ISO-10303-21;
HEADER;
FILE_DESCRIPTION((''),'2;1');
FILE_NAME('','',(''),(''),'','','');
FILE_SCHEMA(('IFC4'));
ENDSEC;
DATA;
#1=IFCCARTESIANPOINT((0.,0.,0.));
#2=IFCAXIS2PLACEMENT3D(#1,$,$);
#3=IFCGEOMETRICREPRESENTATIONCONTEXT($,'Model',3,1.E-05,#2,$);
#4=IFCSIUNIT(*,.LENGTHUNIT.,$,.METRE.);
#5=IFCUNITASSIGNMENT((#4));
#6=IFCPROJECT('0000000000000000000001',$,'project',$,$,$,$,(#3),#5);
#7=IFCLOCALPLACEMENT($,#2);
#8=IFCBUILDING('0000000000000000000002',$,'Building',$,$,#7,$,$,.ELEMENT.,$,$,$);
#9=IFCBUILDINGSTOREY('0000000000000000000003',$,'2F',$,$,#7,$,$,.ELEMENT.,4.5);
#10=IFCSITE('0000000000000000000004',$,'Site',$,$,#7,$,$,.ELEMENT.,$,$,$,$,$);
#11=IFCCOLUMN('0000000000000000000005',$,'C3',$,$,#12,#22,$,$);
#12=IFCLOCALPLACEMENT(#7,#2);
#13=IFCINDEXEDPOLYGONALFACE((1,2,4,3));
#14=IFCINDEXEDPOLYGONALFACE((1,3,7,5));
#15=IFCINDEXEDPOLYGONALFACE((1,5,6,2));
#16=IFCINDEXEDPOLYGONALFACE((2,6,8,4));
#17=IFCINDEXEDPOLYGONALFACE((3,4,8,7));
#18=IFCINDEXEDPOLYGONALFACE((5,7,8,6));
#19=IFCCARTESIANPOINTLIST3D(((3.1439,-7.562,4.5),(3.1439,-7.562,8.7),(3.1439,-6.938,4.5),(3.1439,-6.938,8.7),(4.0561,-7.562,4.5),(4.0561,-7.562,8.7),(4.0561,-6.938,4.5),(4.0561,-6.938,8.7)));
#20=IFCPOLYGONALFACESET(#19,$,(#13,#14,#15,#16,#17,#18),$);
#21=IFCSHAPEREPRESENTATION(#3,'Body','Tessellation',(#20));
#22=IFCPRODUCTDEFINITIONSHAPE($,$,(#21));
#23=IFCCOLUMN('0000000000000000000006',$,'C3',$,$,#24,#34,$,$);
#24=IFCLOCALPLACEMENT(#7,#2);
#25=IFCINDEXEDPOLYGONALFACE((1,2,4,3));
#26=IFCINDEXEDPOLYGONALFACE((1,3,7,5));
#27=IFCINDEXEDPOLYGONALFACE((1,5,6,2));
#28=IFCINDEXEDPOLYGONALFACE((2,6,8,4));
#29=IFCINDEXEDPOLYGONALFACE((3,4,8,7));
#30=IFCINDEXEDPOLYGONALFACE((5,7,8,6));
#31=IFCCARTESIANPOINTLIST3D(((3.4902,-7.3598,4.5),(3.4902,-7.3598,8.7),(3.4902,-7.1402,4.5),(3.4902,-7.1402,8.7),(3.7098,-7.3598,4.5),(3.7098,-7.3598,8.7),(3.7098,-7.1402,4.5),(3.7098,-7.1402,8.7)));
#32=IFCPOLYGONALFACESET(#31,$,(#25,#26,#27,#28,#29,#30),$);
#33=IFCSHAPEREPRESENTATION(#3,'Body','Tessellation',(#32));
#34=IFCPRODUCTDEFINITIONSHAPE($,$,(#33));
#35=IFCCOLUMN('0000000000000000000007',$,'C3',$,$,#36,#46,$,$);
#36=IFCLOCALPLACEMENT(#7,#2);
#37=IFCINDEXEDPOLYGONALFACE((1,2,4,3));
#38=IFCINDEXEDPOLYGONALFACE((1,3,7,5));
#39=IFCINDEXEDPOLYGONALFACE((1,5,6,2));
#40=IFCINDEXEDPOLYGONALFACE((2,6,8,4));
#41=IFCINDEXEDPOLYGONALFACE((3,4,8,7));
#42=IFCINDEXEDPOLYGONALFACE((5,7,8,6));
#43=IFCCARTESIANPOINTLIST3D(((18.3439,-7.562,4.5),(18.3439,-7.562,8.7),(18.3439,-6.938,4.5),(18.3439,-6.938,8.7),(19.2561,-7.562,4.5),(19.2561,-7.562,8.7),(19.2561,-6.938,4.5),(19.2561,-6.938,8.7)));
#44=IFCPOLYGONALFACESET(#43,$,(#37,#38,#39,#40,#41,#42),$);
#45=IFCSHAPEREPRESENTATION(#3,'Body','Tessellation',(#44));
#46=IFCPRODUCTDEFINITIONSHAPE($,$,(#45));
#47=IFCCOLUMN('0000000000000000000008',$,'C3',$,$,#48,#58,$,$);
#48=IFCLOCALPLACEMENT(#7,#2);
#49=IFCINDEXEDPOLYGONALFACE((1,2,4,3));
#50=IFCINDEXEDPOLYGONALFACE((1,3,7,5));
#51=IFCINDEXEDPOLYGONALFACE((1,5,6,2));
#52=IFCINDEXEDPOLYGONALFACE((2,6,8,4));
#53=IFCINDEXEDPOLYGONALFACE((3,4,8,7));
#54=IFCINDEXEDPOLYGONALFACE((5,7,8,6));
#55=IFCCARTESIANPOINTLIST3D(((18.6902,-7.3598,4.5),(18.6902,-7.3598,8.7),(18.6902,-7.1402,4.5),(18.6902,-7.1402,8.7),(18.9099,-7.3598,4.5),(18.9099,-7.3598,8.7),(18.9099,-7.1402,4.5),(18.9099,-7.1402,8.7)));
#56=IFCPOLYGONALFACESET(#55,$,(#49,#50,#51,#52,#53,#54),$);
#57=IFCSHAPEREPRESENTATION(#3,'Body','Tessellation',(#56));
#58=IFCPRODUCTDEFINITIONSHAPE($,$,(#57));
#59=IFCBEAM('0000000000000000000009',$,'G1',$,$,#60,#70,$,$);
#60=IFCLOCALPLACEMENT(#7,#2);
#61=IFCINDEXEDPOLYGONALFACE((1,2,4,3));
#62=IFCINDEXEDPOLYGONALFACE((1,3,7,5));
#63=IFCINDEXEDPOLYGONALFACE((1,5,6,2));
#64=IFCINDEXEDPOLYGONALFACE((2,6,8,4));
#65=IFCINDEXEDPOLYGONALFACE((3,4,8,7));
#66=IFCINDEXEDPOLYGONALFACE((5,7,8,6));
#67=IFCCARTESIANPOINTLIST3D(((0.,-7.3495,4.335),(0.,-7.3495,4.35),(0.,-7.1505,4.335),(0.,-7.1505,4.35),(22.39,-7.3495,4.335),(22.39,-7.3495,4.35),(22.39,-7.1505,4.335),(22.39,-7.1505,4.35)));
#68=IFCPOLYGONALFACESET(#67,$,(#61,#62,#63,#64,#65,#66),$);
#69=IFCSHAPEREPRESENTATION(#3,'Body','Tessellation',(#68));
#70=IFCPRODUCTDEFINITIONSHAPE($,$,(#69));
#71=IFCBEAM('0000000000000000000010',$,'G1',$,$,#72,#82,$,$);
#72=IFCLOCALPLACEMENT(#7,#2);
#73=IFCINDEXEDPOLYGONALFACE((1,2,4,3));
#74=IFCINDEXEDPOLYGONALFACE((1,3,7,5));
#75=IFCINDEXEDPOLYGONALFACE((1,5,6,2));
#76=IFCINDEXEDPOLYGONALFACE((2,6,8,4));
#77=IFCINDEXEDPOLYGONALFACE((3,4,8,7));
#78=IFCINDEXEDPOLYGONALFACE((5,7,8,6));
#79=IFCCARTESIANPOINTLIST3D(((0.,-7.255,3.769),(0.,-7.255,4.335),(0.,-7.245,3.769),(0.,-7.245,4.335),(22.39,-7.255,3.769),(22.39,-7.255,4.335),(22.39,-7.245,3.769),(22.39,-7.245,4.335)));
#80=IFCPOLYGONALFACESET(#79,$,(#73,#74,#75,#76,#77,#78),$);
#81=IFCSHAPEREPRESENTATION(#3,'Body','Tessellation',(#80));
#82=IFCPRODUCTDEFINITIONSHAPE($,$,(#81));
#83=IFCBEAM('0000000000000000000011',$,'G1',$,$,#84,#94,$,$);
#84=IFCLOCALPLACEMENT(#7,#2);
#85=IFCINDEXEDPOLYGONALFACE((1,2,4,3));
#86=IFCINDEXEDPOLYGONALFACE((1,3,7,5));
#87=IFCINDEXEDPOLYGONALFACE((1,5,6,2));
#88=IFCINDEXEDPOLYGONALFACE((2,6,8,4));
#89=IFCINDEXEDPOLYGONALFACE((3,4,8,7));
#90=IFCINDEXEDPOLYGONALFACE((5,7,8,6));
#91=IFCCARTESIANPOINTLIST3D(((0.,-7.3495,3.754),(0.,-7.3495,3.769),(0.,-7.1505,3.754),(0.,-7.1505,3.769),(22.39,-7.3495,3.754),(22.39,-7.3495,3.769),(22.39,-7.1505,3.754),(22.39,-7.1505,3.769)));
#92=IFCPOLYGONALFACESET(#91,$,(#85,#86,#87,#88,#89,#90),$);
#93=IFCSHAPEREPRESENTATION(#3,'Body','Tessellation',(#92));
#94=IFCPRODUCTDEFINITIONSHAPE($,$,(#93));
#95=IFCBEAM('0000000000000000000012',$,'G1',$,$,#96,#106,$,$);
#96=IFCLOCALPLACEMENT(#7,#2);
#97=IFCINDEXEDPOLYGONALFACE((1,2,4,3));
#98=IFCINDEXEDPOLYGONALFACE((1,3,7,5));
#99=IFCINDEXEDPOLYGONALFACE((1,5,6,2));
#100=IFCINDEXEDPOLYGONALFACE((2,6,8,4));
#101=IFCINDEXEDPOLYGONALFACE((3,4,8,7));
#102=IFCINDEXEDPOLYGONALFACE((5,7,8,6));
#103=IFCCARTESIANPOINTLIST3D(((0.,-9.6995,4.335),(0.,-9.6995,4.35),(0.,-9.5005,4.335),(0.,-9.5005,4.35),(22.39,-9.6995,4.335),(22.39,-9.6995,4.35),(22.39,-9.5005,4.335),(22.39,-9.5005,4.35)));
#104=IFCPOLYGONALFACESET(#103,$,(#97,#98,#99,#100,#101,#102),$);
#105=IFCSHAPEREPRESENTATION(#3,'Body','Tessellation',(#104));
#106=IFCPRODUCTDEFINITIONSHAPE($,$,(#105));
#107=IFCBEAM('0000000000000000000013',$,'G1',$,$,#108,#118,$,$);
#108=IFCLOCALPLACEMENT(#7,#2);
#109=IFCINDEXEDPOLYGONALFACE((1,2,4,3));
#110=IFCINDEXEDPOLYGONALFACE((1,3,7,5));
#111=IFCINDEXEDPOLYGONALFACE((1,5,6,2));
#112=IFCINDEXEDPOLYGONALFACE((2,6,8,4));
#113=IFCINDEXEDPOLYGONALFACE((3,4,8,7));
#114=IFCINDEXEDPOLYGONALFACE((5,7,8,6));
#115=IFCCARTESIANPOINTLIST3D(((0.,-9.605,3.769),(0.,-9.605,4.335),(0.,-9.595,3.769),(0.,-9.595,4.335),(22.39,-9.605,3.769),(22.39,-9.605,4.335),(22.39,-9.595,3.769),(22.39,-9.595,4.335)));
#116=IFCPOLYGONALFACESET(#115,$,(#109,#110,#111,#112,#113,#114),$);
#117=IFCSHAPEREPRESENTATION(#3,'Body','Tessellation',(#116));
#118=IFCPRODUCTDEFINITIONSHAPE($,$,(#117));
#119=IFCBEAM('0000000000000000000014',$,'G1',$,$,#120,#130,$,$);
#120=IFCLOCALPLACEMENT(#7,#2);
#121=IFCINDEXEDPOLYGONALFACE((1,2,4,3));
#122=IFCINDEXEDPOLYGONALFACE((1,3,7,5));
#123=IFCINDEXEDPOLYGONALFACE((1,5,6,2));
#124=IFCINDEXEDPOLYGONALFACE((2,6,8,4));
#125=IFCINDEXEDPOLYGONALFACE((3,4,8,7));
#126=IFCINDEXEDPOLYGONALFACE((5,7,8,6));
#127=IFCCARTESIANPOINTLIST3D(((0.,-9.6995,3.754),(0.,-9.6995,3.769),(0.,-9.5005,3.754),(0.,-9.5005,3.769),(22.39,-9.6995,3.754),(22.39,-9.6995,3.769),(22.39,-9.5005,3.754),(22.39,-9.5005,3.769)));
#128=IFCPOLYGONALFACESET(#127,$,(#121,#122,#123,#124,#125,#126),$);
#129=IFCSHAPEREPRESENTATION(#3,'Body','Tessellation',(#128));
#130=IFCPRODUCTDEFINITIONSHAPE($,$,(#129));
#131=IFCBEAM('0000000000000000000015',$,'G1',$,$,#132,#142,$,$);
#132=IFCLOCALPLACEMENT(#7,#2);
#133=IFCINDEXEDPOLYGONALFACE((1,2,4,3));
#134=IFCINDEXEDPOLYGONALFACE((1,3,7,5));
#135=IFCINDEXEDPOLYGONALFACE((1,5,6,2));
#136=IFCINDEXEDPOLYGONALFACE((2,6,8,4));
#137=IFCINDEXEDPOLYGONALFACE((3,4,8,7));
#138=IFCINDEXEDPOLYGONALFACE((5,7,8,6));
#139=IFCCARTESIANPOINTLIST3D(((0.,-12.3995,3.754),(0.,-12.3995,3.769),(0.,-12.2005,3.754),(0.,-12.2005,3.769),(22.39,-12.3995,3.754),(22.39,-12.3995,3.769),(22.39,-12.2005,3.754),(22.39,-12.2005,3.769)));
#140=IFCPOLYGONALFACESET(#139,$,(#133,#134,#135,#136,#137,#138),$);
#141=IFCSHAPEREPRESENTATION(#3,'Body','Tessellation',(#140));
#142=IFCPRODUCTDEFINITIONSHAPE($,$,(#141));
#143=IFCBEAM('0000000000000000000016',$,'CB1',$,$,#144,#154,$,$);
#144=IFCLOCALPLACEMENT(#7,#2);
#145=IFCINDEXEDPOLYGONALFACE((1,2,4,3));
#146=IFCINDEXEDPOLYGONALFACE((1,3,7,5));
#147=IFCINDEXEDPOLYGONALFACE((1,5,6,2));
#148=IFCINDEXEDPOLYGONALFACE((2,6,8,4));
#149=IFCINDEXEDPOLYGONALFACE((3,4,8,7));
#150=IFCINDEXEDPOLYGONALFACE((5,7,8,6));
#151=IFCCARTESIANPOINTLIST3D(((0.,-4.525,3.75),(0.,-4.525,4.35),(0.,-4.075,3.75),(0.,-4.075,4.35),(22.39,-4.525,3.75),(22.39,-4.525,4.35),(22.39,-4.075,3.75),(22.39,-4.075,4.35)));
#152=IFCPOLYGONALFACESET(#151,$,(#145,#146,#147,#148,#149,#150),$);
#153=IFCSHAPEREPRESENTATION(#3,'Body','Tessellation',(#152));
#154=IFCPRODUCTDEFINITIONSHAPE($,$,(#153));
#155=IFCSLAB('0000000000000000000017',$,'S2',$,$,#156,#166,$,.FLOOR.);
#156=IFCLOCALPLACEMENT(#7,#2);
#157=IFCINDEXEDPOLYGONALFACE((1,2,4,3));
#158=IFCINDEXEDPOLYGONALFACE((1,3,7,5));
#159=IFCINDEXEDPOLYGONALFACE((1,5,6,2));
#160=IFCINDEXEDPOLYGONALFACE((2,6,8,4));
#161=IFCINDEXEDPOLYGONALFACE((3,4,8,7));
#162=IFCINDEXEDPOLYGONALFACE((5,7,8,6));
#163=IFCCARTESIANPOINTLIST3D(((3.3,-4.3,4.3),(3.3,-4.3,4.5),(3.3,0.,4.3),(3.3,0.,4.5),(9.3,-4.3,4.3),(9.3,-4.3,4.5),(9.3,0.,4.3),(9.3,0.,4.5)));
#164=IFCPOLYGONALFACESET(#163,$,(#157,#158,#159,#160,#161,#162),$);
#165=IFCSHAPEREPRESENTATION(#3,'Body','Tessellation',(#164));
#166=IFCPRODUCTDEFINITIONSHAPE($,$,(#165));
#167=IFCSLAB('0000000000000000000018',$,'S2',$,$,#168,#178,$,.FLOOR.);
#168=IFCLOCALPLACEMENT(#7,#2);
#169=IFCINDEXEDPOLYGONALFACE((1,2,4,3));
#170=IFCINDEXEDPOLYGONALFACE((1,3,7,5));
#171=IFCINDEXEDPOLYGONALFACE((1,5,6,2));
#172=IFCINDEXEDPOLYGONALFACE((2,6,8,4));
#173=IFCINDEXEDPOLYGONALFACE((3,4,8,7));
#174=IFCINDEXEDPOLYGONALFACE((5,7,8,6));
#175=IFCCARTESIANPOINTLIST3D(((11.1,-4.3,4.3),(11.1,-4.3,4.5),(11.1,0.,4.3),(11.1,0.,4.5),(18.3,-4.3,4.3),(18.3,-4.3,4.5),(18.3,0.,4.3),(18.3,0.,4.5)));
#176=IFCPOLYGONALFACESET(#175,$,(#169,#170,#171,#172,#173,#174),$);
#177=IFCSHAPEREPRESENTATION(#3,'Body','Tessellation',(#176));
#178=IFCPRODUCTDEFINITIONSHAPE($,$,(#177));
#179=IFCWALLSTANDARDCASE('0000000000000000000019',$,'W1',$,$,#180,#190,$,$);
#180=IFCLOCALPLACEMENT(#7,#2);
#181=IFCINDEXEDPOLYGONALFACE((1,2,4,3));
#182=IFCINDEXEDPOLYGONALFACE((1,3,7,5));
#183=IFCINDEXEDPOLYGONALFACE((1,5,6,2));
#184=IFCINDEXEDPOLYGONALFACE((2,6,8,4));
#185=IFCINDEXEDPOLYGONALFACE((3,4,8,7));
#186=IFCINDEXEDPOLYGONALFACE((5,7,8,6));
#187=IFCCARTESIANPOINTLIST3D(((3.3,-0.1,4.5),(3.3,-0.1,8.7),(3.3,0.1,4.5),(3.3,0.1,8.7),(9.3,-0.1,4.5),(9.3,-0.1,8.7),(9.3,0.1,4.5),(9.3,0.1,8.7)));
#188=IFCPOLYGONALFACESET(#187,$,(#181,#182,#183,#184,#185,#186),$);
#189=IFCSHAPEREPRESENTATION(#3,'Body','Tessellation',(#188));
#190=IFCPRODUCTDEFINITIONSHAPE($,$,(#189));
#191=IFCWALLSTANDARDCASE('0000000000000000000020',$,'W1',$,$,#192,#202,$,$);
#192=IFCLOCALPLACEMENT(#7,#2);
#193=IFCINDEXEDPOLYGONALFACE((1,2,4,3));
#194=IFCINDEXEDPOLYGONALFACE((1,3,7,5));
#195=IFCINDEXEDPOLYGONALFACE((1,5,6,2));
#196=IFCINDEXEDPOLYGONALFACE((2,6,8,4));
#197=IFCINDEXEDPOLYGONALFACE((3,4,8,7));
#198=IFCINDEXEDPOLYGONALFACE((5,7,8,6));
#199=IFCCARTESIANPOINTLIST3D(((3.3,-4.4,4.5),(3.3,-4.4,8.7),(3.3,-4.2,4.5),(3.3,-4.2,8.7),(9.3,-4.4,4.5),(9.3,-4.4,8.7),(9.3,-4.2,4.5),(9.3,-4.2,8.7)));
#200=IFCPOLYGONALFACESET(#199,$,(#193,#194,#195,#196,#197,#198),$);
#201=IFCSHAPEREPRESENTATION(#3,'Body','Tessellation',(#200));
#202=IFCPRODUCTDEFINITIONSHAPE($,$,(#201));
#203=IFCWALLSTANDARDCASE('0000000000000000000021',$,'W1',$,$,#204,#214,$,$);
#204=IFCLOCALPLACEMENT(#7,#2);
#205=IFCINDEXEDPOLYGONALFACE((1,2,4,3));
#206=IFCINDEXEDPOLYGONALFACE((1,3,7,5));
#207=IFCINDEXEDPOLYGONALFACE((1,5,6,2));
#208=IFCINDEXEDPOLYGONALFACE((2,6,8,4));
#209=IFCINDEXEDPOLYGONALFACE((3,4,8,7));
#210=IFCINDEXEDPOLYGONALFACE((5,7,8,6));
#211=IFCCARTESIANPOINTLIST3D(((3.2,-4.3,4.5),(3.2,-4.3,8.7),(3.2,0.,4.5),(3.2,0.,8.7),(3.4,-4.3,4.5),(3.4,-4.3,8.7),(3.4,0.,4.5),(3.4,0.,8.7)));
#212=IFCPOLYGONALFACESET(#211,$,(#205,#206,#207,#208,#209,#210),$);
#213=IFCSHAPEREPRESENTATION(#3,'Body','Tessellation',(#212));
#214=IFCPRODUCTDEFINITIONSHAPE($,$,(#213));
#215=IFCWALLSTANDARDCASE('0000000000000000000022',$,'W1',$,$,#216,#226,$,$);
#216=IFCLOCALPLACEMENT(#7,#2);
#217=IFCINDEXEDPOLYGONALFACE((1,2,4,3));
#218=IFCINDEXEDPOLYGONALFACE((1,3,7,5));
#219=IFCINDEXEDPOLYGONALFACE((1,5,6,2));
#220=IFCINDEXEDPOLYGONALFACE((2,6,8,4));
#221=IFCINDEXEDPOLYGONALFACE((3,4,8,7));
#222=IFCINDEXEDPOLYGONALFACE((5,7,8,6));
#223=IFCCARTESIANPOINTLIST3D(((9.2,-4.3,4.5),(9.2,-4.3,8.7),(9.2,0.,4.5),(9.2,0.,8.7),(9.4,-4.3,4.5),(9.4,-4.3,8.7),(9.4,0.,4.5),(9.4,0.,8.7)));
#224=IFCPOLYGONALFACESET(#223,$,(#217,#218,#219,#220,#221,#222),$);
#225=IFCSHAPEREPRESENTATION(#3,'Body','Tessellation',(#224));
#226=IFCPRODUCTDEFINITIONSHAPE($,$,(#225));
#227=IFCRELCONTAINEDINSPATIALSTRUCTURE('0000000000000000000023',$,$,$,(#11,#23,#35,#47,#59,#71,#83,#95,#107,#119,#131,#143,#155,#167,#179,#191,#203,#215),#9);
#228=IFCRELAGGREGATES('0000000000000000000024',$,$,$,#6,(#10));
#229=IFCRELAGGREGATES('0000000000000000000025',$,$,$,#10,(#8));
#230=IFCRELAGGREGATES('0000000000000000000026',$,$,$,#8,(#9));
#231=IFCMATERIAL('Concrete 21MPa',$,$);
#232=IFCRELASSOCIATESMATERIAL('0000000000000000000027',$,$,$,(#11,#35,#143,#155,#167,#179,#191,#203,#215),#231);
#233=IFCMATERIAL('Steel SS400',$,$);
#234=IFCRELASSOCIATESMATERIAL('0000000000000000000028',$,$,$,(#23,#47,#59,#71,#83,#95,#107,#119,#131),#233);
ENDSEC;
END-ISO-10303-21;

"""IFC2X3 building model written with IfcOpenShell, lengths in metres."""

from ifc_helpers import new_model, si_unit, frame, origin, origin_2d, place, context, project, spatial, rectangle, extrude, material, element, save


model = new_model("IFC2X3")

# Units and contexts
model_context = context("Model", 3, precision=1e-05, world=origin())
ifc_project = project(units=[si_unit("LENGTHUNIT", "METRE")], contexts=[model_context])

# Site, building, storey
placement = place(None, origin())
site = spatial("IfcSite", under=ifc_project, at=placement, Name="Site", CompositionType="ELEMENT")
building = spatial("IfcBuilding", under=site, at=placement, Name="Building", CompositionType="ELEMENT")
storey = spatial("IfcBuildingStorey", under=building, at=placement, Name="2F", CompositionType="ELEMENT", Elevation=4.5)

# Columns
ifc_material_1 = material(Name="Concrete 21MPa")
column_1_placement = place(None, frame((3.6, -7.25, 4.5)))
element("IfcColumn", 1, at=column_1_placement, inside=storey, material=ifc_material_1, Name="C3", context=model_context, shape_type="SweptSolid", body=[
    extrude(rectangle(XDim=0.9121, YDim=0.6241, at=origin_2d()), origin(), (0.0, 0.0, 1.0), 4.2),
])
ifc_material_2 = material(Name="Steel SS400")
column_2_placement = place(None, frame((3.6, -7.25, 4.5)))
element("IfcColumn", 2, at=column_2_placement, inside=storey, material=ifc_material_2, Name="C3", context=model_context, shape_type="SweptSolid", body=[
    extrude(rectangle(XDim=0.2197, YDim=0.2197, at=origin_2d()), origin(), (0.0, 0.0, 1.0), 4.2),
])
column_3_placement = place(None, frame((18.8, -7.25, 4.5)))
element("IfcColumn", 3, at=column_3_placement, inside=storey, material=ifc_material_1, Name="C3", context=model_context, shape_type="SweptSolid", body=[
    extrude(rectangle(XDim=0.9121, YDim=0.6241, at=origin_2d()), origin(), (0.0, 0.0, 1.0), 4.2),
])
column_4_placement = place(None, frame((18.8, -7.25, 4.5)))
element("IfcColumn", 4, at=column_4_placement, inside=storey, material=ifc_material_2, Name="C3", context=model_context, shape_type="SweptSolid", body=[
    extrude(rectangle(XDim=0.2197, YDim=0.2197, at=origin_2d()), origin(), (0.0, 0.0, 1.0), 4.2),
])

# Beams
beam_1_placement = place(None, frame((11.195, -7.25, 4.335)))
element("IfcBeam", 5, at=beam_1_placement, inside=storey, material=ifc_material_2, Name="G1", context=model_context, shape_type="SweptSolid", body=[
    extrude(rectangle(XDim=22.39, YDim=0.199, at=origin_2d()), origin(), (0.0, 0.0, 1.0), 0.015),
])
beam_2_placement = place(None, frame((11.195, -7.25, 3.769)))
element("IfcBeam", 6, at=beam_2_placement, inside=storey, material=ifc_material_2, Name="G1", context=model_context, shape_type="SweptSolid", body=[
    extrude(rectangle(XDim=22.39, YDim=0.01, at=origin_2d()), origin(), (0.0, 0.0, 1.0), 0.566),
])
for number, where, name in (
    (7, (11.195, -7.25, 3.754), "G1"),
    (8, (11.195, -9.6, 4.335), "G1"),
):
    element("IfcBeam", number, at=place(None, frame(where)), inside=storey, material=ifc_material_2, Name=name, context=model_context, shape_type="SweptSolid", body=[
        extrude(rectangle(XDim=22.39, YDim=0.199, at=origin_2d()), origin(), (0.0, 0.0, 1.0), 0.015),
    ])
beam_3_placement = place(None, frame((11.195, -9.6, 3.769)))
element("IfcBeam", 9, at=beam_3_placement, inside=storey, material=ifc_material_2, Name="G1", context=model_context, shape_type="SweptSolid", body=[
    extrude(rectangle(XDim=22.39, YDim=0.01, at=origin_2d()), origin(), (0.0, 0.0, 1.0), 0.566),
])
for number, where, name in (
    (10, (11.195, -9.6, 3.754), "G1"),
    (11, (11.195, -12.3, 3.754), "G1"),
):
    element("IfcBeam", number, at=place(None, frame(where)), inside=storey, material=ifc_material_2, Name=name, context=model_context, shape_type="SweptSolid", body=[
        extrude(rectangle(XDim=22.39, YDim=0.199, at=origin_2d()), origin(), (0.0, 0.0, 1.0), 0.015),
    ])
beam_4_placement = place(None, frame((11.195, -4.3, 3.75)))
element("IfcBeam", 12, at=beam_4_placement, inside=storey, material=ifc_material_1, Name="CB1", context=model_context, shape_type="SweptSolid", body=[
    extrude(rectangle(XDim=22.39, YDim=0.45, at=origin_2d()), origin(), (0.0, 0.0, 1.0), 0.6),
])

# Slabs
slab_1_placement = place(None, frame((6.3, -2.15, 4.3)))
element("IfcSlab", 13, at=slab_1_placement, inside=storey, material=ifc_material_1, Name="S2", PredefinedType="FLOOR", context=model_context, shape_type="SweptSolid", body=[
    extrude(rectangle(XDim=6.0, YDim=4.3, at=origin_2d()), origin(), (0.0, 0.0, 1.0), 0.2),
])
slab_2_placement = place(None, frame((14.7, -2.15, 4.3)))
element("IfcSlab", 14, at=slab_2_placement, inside=storey, material=ifc_material_1, Name="S2", PredefinedType="FLOOR", context=model_context, shape_type="SweptSolid", body=[
    extrude(rectangle(XDim=7.2, YDim=4.3, at=origin_2d()), origin(), (0.0, 0.0, 1.0), 0.2),
])

# Walls
for number, where, name in (
    (15, (6.3, 0.0, 4.5), "W1"),
    (16, (6.3, -4.3, 4.5), "W1"),
):
    element("IfcWallStandardCase", number, at=place(None, frame(where)), inside=storey, material=ifc_material_1, Name=name, context=model_context, shape_type="SweptSolid", body=[
        extrude(rectangle(XDim=6.0, YDim=0.2, at=origin_2d()), origin(), (0.0, 0.0, 1.0), 4.2),
    ])
for number, where, name in (
    (17, (3.3, -2.15, 4.5), "W1"),
    (18, (9.3, -2.15, 4.5), "W1"),
):
    element("IfcWallStandardCase", number, at=place(None, frame(where)), inside=storey, material=ifc_material_1, Name=name, context=model_context, shape_type="SweptSolid", body=[
        extrude(rectangle(XDim=0.2, YDim=4.3, at=origin_2d()), origin(), (0.0, 0.0, 1.0), 4.2),
    ])

save(model, "model.ifc")
